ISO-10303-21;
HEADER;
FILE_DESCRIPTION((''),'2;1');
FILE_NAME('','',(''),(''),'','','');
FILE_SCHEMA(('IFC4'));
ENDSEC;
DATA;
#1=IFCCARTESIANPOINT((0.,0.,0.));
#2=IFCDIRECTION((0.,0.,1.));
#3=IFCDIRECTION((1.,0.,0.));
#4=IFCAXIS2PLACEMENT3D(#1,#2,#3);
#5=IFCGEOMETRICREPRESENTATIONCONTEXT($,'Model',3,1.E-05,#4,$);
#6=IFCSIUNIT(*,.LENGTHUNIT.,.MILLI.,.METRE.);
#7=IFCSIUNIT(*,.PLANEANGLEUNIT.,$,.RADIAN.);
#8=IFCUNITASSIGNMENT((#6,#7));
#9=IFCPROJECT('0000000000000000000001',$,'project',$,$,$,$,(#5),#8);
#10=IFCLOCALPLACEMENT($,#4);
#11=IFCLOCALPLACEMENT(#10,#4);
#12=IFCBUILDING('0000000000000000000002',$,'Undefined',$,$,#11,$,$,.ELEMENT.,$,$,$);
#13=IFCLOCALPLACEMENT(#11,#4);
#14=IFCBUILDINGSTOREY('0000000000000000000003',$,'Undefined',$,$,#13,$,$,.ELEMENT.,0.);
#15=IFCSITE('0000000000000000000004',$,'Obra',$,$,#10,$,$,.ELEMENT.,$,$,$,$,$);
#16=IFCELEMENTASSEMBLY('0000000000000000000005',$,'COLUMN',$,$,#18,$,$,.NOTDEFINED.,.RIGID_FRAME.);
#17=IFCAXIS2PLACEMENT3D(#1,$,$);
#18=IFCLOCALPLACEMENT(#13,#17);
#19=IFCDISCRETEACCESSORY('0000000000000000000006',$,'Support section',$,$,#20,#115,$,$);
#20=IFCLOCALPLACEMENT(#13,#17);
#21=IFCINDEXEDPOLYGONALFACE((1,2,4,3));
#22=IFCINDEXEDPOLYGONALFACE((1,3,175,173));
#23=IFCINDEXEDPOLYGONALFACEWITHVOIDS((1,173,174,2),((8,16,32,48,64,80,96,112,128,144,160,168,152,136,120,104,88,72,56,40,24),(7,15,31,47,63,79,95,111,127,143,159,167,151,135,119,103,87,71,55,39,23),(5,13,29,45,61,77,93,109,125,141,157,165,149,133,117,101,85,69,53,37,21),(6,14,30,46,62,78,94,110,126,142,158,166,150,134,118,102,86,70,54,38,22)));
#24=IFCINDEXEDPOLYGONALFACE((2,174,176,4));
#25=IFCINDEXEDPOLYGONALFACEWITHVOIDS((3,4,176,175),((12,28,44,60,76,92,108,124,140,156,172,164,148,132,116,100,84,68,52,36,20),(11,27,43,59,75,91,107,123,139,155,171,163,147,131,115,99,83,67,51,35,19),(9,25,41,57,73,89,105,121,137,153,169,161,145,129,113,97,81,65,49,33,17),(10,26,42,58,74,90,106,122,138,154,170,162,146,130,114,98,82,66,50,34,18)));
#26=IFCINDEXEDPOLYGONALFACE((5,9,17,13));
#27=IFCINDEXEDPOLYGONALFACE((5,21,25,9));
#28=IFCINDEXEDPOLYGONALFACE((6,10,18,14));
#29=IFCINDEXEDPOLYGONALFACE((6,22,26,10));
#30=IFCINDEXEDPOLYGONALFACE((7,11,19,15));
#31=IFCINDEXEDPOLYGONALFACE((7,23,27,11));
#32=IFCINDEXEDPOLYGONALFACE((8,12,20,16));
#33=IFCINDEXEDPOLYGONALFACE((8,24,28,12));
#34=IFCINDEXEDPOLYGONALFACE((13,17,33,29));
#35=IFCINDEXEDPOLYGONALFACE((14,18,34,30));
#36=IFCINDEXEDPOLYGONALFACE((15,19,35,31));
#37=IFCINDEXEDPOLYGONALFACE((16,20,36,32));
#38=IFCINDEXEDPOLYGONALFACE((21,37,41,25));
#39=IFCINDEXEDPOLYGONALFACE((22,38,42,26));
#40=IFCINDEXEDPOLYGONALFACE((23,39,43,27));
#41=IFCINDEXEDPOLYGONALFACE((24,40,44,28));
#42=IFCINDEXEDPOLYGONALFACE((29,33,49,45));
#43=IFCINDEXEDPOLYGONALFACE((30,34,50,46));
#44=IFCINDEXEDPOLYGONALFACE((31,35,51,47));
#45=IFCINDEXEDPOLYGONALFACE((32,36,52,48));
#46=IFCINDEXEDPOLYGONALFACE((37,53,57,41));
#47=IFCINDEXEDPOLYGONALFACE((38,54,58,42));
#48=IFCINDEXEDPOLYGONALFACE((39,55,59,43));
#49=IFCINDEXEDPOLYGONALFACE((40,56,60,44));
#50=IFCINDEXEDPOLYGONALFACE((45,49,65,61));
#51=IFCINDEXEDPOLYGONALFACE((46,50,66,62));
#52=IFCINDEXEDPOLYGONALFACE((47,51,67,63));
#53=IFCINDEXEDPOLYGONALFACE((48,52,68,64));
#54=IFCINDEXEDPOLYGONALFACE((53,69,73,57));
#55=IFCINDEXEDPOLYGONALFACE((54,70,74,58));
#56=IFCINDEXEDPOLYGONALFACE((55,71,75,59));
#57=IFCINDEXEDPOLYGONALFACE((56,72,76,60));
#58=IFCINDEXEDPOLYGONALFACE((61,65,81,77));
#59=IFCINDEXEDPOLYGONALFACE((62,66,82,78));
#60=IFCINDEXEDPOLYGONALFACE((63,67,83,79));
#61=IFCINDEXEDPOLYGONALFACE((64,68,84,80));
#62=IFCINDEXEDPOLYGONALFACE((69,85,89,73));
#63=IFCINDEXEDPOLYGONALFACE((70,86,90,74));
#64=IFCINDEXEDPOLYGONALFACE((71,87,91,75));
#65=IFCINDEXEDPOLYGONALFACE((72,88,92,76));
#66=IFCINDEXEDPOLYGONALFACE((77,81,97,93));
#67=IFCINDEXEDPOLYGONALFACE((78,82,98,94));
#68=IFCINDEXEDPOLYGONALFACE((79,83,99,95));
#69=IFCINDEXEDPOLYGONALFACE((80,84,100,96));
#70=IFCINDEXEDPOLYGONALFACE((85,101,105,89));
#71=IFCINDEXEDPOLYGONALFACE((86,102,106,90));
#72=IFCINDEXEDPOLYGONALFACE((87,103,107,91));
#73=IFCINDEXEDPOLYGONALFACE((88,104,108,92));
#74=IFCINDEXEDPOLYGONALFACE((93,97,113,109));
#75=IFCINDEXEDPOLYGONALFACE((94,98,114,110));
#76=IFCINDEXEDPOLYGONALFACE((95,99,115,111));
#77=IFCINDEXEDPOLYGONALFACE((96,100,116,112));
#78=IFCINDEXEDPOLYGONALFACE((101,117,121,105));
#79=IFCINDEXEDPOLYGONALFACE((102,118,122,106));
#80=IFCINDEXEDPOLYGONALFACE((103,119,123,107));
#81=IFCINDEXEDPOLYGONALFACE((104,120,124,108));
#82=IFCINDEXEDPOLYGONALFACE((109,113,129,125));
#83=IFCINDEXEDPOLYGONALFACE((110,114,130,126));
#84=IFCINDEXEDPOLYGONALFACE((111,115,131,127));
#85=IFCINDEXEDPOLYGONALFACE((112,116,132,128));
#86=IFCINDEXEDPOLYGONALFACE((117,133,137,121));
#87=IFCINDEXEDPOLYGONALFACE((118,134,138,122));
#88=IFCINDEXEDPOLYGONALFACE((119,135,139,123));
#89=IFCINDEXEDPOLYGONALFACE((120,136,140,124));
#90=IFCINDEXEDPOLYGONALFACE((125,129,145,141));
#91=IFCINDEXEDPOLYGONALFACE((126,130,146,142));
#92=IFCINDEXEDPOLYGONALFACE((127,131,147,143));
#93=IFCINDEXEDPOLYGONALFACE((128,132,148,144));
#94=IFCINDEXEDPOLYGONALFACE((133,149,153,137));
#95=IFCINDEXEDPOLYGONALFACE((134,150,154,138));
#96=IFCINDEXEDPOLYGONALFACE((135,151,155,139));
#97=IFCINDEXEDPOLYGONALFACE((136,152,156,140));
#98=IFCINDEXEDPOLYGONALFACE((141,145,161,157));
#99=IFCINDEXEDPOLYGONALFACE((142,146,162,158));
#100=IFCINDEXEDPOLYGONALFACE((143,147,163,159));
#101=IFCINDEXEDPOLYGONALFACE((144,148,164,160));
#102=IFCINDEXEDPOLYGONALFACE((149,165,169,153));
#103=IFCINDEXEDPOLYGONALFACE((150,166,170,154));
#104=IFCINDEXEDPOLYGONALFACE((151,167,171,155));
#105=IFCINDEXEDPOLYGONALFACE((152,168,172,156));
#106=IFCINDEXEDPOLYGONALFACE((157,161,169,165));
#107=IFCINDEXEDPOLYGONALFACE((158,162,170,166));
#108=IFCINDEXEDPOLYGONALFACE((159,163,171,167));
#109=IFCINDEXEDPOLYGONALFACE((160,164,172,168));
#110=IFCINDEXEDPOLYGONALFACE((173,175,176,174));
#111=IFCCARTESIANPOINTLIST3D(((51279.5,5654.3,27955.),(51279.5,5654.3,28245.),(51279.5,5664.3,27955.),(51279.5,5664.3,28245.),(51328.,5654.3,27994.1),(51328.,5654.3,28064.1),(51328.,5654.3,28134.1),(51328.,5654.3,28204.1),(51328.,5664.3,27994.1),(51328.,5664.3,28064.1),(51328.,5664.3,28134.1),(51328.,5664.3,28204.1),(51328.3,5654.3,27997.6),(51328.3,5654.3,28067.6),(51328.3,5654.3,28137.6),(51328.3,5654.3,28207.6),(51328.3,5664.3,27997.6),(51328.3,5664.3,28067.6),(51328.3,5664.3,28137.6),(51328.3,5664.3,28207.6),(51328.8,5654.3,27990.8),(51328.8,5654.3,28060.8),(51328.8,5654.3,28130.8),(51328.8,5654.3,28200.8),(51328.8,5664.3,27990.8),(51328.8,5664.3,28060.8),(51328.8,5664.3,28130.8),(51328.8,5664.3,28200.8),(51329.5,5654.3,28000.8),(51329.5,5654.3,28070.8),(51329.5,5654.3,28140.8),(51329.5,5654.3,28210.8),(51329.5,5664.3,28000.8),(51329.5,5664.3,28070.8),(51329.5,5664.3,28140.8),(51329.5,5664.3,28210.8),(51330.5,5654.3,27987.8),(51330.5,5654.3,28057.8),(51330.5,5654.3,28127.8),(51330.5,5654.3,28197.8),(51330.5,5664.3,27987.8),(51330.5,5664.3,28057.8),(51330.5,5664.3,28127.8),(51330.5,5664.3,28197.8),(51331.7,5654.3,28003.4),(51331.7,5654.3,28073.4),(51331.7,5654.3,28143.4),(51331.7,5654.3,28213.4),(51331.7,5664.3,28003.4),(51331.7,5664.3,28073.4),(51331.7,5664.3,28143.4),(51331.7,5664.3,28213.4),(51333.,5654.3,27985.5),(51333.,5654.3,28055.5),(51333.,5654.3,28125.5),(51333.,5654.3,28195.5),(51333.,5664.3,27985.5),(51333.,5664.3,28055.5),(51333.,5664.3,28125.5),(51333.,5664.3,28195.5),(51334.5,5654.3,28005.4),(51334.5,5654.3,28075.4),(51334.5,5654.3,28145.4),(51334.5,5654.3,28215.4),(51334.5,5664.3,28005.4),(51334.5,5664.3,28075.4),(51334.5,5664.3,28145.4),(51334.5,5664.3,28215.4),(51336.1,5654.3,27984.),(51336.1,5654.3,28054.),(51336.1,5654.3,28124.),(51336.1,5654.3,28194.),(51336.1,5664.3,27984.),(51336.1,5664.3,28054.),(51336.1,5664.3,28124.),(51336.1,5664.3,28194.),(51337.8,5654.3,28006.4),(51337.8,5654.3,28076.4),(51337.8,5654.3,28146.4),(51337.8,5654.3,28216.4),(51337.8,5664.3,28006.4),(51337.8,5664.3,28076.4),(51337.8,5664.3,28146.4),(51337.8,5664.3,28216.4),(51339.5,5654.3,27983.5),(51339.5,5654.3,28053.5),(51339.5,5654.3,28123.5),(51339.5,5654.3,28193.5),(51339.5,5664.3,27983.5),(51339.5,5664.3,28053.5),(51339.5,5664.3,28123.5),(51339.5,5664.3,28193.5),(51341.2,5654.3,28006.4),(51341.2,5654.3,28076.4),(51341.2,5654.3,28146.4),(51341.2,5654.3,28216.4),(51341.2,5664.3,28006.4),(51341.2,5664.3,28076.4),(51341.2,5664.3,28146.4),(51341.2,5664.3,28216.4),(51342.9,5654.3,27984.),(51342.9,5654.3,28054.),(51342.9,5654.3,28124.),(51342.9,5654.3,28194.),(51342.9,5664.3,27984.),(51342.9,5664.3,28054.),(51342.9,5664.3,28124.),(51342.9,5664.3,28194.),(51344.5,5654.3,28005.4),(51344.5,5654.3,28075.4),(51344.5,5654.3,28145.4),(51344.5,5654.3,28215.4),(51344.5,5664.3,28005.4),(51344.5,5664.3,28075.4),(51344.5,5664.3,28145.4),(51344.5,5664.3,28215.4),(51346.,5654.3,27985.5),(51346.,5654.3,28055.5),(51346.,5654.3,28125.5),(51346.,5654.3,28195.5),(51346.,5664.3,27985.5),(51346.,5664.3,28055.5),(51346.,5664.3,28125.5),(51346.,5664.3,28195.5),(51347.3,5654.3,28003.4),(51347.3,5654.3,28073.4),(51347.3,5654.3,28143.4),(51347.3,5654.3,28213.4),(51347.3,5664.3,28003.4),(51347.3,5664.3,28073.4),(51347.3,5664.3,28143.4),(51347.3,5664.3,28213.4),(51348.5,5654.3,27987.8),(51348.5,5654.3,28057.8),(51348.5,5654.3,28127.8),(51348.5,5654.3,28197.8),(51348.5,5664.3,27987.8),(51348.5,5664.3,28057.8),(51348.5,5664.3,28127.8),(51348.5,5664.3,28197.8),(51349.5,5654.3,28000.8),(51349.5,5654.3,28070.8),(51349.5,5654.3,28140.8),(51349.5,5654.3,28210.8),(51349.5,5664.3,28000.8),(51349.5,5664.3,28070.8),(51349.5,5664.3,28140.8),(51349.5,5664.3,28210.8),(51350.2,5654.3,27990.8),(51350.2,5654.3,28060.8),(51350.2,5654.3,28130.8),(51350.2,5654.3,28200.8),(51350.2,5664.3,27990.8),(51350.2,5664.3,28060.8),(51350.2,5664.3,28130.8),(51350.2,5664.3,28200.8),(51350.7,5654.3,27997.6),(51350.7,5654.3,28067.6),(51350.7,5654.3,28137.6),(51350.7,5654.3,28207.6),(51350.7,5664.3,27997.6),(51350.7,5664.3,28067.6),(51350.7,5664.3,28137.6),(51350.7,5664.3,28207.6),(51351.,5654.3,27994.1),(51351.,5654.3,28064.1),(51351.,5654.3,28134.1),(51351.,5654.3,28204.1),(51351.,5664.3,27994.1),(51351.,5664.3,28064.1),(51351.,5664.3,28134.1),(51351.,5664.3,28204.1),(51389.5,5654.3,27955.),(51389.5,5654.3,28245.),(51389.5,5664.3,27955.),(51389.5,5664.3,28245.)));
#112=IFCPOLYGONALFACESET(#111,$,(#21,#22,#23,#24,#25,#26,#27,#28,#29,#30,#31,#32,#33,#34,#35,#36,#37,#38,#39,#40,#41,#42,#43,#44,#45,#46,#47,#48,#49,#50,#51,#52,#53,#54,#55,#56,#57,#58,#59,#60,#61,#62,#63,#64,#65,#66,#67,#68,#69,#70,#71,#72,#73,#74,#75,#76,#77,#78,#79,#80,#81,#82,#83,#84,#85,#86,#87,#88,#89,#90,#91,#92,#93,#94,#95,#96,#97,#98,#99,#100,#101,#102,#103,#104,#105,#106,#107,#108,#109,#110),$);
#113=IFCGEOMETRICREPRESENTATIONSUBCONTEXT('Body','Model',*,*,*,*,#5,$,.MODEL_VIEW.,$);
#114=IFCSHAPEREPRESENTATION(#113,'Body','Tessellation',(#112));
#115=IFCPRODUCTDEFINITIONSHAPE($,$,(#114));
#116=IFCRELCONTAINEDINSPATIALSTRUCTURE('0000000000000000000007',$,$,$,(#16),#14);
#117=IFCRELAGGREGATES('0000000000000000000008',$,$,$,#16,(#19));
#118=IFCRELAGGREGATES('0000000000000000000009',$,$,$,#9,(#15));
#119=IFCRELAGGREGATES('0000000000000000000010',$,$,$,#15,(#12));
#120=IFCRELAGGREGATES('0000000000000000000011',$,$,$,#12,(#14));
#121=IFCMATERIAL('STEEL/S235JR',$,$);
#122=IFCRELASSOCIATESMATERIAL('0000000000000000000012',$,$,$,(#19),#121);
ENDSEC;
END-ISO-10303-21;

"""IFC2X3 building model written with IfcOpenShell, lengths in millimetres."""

from ifc_helpers import new_model, si_unit, frame, origin_with_axes, origin_2d_with_axis, place, context, subcontext, project, spatial, rectangle, circle, extrude, source, transform, mapped, material, element, aggregate, save


model = new_model("IFC2X3")

# Units and contexts
model_context = context("Model", 3, precision=1e-05, world=origin_with_axes())
body_context = subcontext(model_context, "Body", "Model", "MODEL_VIEW")
ifc_project = project(units=[si_unit("LENGTHUNIT", "METRE", prefix="MILLI"), si_unit("PLANEANGLEUNIT", "RADIAN")], contexts=[model_context])

# Site, building, storey
site_placement = place(None, origin_with_axes())
site = spatial("IfcSite", under=ifc_project, at=site_placement, Name="Obra", CompositionType="ELEMENT")
building_placement = place(site_placement, origin_with_axes())
building = spatial("IfcBuilding", under=site, at=building_placement, Name="Undefined", CompositionType="ELEMENT")
storey_placement = place(building_placement, origin_with_axes())
storey = spatial("IfcBuildingStorey", under=building, at=storey_placement, Name="Undefined", CompositionType="ELEMENT", Elevation=0.0)

# Shared definitions
ifc_material_1 = material(Name="STEEL/S235JR")

# Shared definitions
shared_shape_1 = source(origin_with_axes(), body_context, "Body", "SweptSolid", [
    extrude(circle(Radius=11.5, at=origin_2d_with_axis()), frame((0.0, -14.4, 0.0), z_axis=(0.0, 1.0, 0.0), x_axis=(1.0, 0.0, 0.0)), (0.0, 0.0, 1.0), 10.2),
])

# Element assembly, discrete accessory, opening
assembly_1_placement = place(storey_placement, origin_with_axes())
assembly_1 = element("IfcElementAssembly", 1, at=assembly_1_placement, inside=storey, Name="COLUMN", AssemblyPlace="NOTDEFINED", PredefinedType="RIGID_FRAME")
discrete_accessory_1_placement = place(assembly_1_placement, frame((51334.5, 5659.3, 27955.0), z_axis=(0.0, 0.0, 1.0), x_axis=(-1.0, 0.0, 0.0)))
discrete_accessory_1 = element("IfcDiscreteAccessory", 2, at=discrete_accessory_1_placement, material=ifc_material_1, Name="Support section", context=body_context, shape_type="SweptSolid", body=[
    extrude(rectangle(XDim=10.0, YDim=110.0, at=origin_2d_with_axis()), frame((0.0, 0.0, 290.0), z_axis=(0.0, 0.0, -1.0), x_axis=(0.0, 1.0, 0.0)), (0.0, 0.0, 1.0), 290.0),
])
opening_1_placement = place(assembly_1_placement, frame((51289.5, 5668.6, 28300.0), z_axis=(1.0, 0.0, 0.0), x_axis=(0.0, 0.0, -1.0)))
element("IfcOpeningElement", 3, at=opening_1_placement, cuts=discrete_accessory_1, ObjectType="Opening", context=body_context, shape_type="MappedRepresentation", body=[
    mapped(shared_shape_1, transform((95.0, 0.0, 50.0))),
    mapped(shared_shape_1, transform((165.0, 0.0, 50.0))),
    mapped(shared_shape_1, transform((235.0, 0.0, 50.0))),
    mapped(shared_shape_1, transform((305.0, 0.0, 50.0))),
])
aggregate(assembly_1, [discrete_accessory_1])

save(model, "model.ifc")
